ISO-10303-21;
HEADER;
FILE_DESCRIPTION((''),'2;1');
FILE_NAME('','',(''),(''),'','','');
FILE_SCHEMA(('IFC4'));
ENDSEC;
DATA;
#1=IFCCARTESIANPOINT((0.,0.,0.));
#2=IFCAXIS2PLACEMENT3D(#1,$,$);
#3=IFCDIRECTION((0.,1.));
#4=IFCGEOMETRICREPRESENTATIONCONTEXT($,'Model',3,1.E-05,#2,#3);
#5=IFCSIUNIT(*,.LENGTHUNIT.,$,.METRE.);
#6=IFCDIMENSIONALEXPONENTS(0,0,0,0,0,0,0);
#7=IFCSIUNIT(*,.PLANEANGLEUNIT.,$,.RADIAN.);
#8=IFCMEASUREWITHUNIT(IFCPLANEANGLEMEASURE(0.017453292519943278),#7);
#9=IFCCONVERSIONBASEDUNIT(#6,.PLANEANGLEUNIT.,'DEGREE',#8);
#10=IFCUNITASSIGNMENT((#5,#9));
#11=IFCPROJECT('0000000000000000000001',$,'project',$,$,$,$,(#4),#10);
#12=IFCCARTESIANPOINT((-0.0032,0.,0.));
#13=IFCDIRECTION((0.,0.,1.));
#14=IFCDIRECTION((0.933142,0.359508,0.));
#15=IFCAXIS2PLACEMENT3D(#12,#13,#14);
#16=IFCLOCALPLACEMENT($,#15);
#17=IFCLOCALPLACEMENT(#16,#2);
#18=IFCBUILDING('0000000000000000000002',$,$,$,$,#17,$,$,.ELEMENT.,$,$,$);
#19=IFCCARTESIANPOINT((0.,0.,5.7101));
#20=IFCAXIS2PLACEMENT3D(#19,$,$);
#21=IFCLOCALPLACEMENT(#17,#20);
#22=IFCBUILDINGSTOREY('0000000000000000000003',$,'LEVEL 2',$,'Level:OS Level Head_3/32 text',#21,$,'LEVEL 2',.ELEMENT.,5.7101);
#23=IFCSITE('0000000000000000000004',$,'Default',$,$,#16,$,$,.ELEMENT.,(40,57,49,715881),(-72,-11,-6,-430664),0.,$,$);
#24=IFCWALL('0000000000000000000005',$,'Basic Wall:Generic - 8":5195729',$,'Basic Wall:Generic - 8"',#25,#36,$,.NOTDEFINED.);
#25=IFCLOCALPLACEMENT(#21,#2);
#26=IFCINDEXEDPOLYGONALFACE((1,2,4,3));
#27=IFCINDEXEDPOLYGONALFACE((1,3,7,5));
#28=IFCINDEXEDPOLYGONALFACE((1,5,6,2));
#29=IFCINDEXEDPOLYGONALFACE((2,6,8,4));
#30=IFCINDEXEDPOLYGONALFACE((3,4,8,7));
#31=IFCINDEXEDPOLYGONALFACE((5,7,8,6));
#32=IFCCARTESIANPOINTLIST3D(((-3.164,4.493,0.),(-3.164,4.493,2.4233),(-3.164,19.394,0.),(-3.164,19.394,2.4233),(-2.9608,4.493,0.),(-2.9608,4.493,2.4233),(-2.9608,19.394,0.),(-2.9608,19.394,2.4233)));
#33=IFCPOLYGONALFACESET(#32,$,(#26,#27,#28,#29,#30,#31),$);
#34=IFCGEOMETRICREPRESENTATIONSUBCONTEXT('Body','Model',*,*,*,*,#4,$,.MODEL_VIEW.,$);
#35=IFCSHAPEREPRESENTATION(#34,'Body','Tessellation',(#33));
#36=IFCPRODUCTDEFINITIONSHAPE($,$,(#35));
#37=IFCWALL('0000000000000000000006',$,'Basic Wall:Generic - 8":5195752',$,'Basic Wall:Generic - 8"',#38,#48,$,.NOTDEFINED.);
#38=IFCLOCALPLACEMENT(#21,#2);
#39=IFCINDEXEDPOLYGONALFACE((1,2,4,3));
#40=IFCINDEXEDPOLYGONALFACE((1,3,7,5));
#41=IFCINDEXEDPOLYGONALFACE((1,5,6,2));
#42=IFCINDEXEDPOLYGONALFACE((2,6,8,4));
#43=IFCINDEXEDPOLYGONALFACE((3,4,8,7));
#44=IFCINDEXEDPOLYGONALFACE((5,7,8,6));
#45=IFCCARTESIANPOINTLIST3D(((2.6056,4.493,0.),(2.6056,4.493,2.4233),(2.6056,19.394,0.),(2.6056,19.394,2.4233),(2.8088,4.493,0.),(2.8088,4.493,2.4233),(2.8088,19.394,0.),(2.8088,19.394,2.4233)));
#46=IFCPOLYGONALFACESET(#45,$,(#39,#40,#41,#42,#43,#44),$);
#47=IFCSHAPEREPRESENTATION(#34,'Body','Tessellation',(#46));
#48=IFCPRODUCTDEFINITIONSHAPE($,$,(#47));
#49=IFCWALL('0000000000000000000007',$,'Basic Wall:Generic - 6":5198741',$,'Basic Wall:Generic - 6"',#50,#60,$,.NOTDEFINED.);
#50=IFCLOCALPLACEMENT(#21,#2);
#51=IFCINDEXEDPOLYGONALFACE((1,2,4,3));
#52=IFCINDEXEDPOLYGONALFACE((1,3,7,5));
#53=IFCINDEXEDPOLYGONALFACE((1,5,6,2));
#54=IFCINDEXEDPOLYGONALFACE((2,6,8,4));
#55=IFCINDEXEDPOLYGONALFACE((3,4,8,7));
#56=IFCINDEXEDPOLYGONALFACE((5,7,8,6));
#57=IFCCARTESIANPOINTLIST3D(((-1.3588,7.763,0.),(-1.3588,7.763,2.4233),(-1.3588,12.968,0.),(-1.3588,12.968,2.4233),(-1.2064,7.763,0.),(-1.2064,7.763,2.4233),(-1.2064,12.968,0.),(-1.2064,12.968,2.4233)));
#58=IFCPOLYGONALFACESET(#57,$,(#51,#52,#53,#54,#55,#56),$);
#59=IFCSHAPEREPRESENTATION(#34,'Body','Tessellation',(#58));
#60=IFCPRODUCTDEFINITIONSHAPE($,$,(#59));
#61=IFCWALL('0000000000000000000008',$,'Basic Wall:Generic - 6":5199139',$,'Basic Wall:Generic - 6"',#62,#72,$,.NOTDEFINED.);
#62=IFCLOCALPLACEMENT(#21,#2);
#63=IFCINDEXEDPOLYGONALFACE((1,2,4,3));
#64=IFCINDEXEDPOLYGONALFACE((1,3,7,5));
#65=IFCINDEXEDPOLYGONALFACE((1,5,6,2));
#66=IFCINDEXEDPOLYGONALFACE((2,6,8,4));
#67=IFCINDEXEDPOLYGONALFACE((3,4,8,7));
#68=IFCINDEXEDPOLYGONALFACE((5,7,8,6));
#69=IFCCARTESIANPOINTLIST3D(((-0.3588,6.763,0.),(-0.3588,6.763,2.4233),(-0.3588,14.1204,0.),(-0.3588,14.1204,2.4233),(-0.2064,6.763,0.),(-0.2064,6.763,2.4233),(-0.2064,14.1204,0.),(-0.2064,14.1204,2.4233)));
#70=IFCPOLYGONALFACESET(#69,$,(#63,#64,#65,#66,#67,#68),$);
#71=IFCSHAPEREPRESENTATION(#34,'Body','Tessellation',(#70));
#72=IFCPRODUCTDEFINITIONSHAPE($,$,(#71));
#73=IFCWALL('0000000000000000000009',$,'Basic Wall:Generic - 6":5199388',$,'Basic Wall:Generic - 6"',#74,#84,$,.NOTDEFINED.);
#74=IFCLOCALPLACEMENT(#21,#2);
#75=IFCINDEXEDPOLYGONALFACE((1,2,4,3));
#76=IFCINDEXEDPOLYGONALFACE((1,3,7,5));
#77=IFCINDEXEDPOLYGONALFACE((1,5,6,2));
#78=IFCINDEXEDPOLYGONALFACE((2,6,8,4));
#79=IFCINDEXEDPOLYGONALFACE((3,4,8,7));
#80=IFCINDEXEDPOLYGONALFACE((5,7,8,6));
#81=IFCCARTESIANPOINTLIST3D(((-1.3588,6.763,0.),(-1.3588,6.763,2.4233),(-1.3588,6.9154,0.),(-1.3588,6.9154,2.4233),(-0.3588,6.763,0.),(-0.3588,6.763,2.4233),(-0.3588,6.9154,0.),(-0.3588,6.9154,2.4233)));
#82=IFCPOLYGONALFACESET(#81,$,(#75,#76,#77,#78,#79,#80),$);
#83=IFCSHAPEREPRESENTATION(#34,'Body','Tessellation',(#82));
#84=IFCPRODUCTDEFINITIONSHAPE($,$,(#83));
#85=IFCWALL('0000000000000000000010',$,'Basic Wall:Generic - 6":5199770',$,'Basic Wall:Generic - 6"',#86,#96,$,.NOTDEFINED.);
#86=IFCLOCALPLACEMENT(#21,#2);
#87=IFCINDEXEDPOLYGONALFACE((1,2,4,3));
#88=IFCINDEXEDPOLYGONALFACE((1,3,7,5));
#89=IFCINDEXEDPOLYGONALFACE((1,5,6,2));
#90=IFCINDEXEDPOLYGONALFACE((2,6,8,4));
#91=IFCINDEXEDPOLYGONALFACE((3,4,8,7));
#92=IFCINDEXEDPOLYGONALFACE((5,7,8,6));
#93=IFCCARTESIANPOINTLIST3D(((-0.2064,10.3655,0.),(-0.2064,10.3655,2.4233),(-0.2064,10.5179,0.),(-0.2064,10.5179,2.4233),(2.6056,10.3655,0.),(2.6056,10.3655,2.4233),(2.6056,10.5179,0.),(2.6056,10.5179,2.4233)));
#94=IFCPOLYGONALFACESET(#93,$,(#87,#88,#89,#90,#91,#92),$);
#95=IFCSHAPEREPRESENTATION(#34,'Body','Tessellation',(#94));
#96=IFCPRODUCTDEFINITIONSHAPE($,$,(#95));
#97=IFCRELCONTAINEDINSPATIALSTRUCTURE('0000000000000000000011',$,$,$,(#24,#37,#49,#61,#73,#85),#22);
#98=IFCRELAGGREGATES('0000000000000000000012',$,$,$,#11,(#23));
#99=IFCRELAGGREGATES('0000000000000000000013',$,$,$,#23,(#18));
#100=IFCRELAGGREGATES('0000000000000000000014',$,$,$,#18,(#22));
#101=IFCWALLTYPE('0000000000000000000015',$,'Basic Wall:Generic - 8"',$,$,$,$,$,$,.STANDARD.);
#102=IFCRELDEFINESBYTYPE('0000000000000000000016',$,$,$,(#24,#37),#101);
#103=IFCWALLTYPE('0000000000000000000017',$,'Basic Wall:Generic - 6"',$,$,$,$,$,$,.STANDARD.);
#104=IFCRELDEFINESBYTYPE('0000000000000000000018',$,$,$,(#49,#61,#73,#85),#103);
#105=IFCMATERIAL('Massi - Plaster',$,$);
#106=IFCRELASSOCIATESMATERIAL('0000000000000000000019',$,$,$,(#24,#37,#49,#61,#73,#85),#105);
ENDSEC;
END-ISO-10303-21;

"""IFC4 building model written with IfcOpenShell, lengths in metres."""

from ifc_helpers import new_model, entity, si_unit, converted_unit, direction, frame, origin, place, context, subcontext, project, spatial, indexed_curve, outline, extrude, material, type_object, element, save


model = new_model("IFC4")

# Units and contexts
model_context = context("Model", 3, precision=1e-05, world=origin(), true_north=direction((0.0, 1.0)))
body_context = subcontext(model_context, "Body", "Model", "MODEL_VIEW")
ifc_project = project(units=[si_unit("LENGTHUNIT", "METRE"), converted_unit("PLANEANGLEUNIT", "DEGREE", entity("IfcPlaneAngleMeasure", 0.017453292519943278), si_unit("PLANEANGLEUNIT", "RADIAN"), dimensions=[0, 0, 0, 0, 0, 0, 0])], contexts=[model_context])

# Site, building, storey
site_placement = place(None, frame((-0.0032, 0.0, 0.0), z_axis=(0.0, 0.0, 1.0), x_axis=(0.933142, 0.359508, 0.0)))
site = spatial("IfcSite", under=ifc_project, at=site_placement, Name="Default", CompositionType="ELEMENT", RefLatitude=(40, 57, 49, 715881), RefLongitude=(-72, -11, -6, -430664), RefElevation=0.0)
building_placement = place(site_placement, origin())
building = spatial("IfcBuilding", under=site, at=building_placement, CompositionType="ELEMENT")
storey_placement = place(building_placement, frame((0.0, 0.0, 5.7101)))
storey = spatial("IfcBuildingStorey", under=building, at=storey_placement, Name="LEVEL 2", ObjectType="Level:OS Level Head_3/32 text", LongName="LEVEL 2", CompositionType="ELEMENT", Elevation=5.7101)

# Walls
ifc_material_1 = material(Name="Massi - Plaster")
wall_type_1 = type_object("IfcWallType", Name="Basic Wall:Generic - 8\"", PredefinedType="STANDARD")
wall_1_placement = place(storey_placement, frame((-3.0624, 4.493, 0.0), z_axis=(0.0, 0.0, 1.0), x_axis=(0.0, 1.0, 0.0)))
element("IfcWall", 1, at=wall_1_placement, inside=storey, type_object=wall_type_1, material=ifc_material_1, Name="Basic Wall:Generic - 8\":5195729", ObjectType="Basic Wall:Generic - 8\"", PredefinedType="NOTDEFINED", context=body_context, shape_type="SweptSolid", body=[
    extrude(outline(indexed_curve([(14.901, 0.1016), (0.0, 0.1016), (0.0, -0.1016), (14.901, -0.1016), (14.901, 0.1016)], self_intersect=False)), origin(), (0.0, 0.0, 1.0), 2.4233),
])
wall_2_placement = place(storey_placement, frame((2.7072, 19.394, 0.0), z_axis=(0.0, 0.0, 1.0), x_axis=(0.0, -1.0, 0.0)))
element("IfcWall", 2, at=wall_2_placement, inside=storey, type_object=wall_type_1, material=ifc_material_1, Name="Basic Wall:Generic - 8\":5195752", ObjectType="Basic Wall:Generic - 8\"", PredefinedType="NOTDEFINED", context=body_context, shape_type="SweptSolid", body=[
    extrude(outline(indexed_curve([(14.901, 0.1016), (0.0, 0.1016), (0.0, -0.1016), (14.901, -0.1016), (14.901, 0.1016)], self_intersect=False)), origin(), (0.0, 0.0, 1.0), 2.4233),
])
wall_type_2 = type_object("IfcWallType", Name="Basic Wall:Generic - 6\"", PredefinedType="STANDARD")
wall_3_placement = place(storey_placement, frame((-1.2826, 12.968, 0.0), z_axis=(0.0, 0.0, 1.0), x_axis=(0.0, -1.0, 0.0)))
element("IfcWall", 3, at=wall_3_placement, inside=storey, type_object=wall_type_2, material=ifc_material_1, Name="Basic Wall:Generic - 6\":5198741", ObjectType="Basic Wall:Generic - 6\"", PredefinedType="NOTDEFINED", context=body_context, shape_type="SweptSolid", body=[
    extrude(outline(indexed_curve([(5.205, 0.0762), (0.0, 0.0762), (0.0, -0.0762), (5.205, -0.0762), (5.205, 0.0762)], self_intersect=False)), origin(), (0.0, 0.0, 1.0), 2.4233),
])
wall_4_placement = place(storey_placement, frame((-0.2826, 14.1204, 0.0), z_axis=(0.0, 0.0, 1.0), x_axis=(0.0, -1.0, 0.0)))
element("IfcWall", 4, at=wall_4_placement, inside=storey, type_object=wall_type_2, material=ifc_material_1, Name="Basic Wall:Generic - 6\":5199139", ObjectType="Basic Wall:Generic - 6\"", PredefinedType="NOTDEFINED", context=body_context, shape_type="SweptSolid", body=[
    extrude(outline(indexed_curve([(7.3574, 0.0762), (0.0, 0.0762), (0.0, -0.0762), (7.3574, -0.0762), (7.3574, 0.0762)], self_intersect=False)), origin(), (0.0, 0.0, 1.0), 2.4233),
])
wall_5_placement = place(storey_placement, frame((-1.3588, 6.8392, 0.0)))
element("IfcWall", 5, at=wall_5_placement, inside=storey, type_object=wall_type_2, material=ifc_material_1, Name="Basic Wall:Generic - 6\":5199388", ObjectType="Basic Wall:Generic - 6\"", PredefinedType="NOTDEFINED", context=body_context, shape_type="SweptSolid", body=[
    extrude(outline(indexed_curve([(1.0, 0.0762), (0.0, 0.0762), (0.0, -0.0762), (1.0, -0.0762), (1.0, 0.0762)], self_intersect=False)), origin(), (0.0, 0.0, 1.0), 2.4233),
])
wall_6_placement = place(storey_placement, frame((-0.2064, 10.4417, 0.0)))
element("IfcWall", 6, at=wall_6_placement, inside=storey, type_object=wall_type_2, material=ifc_material_1, Name="Basic Wall:Generic - 6\":5199770", ObjectType="Basic Wall:Generic - 6\"", PredefinedType="NOTDEFINED", context=body_context, shape_type="SweptSolid", body=[
    extrude(outline(indexed_curve([(2.812, 0.0762), (0.0, 0.0762), (0.0, -0.0762), (2.812, -0.0762), (2.812, 0.0762)], self_intersect=False)), origin(), (0.0, 0.0, 1.0), 2.4233),
])

save(model, "model.ifc")
